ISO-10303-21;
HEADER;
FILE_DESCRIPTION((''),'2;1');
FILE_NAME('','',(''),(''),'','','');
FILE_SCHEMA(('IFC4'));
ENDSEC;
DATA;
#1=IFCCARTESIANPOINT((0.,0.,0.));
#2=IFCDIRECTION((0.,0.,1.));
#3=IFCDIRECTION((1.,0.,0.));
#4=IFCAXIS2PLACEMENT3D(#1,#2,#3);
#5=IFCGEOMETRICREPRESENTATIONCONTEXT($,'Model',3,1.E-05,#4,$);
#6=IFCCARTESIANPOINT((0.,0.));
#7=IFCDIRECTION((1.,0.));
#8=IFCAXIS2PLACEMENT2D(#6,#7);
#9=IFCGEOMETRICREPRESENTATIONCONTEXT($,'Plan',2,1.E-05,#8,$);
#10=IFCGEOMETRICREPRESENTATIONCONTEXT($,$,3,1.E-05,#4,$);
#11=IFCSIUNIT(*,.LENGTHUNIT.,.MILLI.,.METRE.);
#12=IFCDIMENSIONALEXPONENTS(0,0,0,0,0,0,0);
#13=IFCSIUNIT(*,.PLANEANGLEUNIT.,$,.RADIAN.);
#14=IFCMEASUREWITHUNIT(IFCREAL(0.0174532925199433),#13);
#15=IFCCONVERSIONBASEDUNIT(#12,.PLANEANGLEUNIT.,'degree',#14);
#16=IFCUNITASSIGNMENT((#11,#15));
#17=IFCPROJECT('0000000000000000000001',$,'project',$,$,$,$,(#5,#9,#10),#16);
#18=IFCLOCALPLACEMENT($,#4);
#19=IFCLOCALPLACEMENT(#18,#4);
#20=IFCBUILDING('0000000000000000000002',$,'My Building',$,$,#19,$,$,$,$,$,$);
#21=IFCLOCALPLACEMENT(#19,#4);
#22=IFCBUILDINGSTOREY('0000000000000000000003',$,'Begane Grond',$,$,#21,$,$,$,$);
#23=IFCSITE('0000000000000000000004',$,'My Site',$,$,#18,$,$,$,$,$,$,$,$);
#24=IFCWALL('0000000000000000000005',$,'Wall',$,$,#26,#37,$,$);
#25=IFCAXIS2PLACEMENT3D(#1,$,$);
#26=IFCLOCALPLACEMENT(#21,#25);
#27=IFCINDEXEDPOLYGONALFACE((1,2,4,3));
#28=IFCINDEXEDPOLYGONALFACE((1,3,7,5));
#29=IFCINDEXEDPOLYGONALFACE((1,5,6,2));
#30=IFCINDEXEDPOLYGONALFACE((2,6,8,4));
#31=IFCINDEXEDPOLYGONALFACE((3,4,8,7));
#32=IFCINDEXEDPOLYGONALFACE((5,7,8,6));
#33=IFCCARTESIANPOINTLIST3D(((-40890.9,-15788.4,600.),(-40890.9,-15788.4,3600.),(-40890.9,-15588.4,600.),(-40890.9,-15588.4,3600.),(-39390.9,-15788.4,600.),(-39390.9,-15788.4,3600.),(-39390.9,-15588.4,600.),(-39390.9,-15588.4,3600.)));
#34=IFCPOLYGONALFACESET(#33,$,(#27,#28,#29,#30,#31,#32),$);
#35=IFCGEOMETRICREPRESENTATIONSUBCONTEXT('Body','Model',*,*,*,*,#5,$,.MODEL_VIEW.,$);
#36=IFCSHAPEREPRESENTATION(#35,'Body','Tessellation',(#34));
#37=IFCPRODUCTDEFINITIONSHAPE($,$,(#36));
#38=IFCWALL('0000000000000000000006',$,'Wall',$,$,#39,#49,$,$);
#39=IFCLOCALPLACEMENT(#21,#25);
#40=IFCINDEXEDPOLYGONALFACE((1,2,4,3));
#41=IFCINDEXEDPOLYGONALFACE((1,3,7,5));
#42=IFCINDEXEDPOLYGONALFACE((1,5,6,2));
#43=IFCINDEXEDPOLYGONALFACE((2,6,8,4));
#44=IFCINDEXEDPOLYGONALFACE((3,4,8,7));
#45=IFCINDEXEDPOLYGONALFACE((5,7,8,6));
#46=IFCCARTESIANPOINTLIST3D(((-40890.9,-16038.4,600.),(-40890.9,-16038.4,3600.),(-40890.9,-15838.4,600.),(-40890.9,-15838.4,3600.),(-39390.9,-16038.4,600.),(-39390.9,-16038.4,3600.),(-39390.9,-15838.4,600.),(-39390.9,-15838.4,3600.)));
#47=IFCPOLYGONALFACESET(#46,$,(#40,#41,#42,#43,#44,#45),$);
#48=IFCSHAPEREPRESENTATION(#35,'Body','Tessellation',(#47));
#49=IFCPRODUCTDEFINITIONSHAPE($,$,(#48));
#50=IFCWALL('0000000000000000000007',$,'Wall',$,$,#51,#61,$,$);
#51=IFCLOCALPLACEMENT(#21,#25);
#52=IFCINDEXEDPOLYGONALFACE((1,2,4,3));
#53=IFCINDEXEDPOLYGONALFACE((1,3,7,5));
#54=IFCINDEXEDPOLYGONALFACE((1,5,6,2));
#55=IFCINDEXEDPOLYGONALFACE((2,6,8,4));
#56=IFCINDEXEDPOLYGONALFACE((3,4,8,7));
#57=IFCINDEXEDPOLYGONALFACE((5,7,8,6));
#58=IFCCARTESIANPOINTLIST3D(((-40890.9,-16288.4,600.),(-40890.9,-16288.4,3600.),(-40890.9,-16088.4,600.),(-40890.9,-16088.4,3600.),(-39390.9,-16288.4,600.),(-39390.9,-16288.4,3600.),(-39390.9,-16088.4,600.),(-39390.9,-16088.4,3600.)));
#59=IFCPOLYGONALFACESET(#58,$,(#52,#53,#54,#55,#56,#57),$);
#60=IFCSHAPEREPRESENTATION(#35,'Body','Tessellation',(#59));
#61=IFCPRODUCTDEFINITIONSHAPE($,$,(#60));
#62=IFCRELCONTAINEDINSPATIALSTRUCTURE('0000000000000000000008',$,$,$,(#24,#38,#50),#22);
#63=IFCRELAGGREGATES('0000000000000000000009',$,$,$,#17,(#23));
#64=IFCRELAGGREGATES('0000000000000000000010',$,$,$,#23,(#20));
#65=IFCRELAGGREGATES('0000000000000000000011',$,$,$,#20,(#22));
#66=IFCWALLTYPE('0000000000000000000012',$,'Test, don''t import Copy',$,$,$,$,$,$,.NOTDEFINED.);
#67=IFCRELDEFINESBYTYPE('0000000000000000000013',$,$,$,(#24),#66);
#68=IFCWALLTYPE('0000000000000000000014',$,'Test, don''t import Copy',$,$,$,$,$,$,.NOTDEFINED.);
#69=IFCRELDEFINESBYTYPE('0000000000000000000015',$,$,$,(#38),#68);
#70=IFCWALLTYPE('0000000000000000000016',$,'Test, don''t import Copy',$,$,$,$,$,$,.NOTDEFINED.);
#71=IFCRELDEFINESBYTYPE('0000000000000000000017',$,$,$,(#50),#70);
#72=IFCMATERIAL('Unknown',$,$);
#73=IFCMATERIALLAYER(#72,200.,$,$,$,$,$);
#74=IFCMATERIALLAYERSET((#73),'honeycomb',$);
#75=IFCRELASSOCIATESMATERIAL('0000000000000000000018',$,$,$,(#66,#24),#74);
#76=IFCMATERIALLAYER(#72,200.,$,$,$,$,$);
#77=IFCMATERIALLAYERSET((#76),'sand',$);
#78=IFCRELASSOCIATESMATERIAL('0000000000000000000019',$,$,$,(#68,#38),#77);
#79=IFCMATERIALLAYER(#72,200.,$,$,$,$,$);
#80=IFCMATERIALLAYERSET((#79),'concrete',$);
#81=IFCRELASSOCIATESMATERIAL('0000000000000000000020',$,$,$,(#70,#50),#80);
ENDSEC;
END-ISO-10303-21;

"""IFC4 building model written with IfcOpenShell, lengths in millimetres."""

from ifc_helpers import new_model, entity, si_unit, converted_unit, frame, origin_with_axes, origin_2d_with_axis, place, context, subcontext, project, spatial, indexed_curve, outline, extrude, material, layer, layer_set, layer_usage, type_object, element, save


model = new_model("IFC4")

# Units and contexts
model_context = context("Model", 3, precision=1e-05, world=origin_with_axes())
plan_context = context("Plan", 2, precision=1e-05, world=origin_2d_with_axis())
context_of_model = context(None, 3, precision=1e-05, world=origin_with_axes())
body_context = subcontext(model_context, "Body", "Model", "MODEL_VIEW")
ifc_project = project(units=[si_unit("LENGTHUNIT", "METRE", prefix="MILLI"), converted_unit("PLANEANGLEUNIT", "degree", entity("IfcReal", 0.0174532925199433), si_unit("PLANEANGLEUNIT", "RADIAN"), dimensions=[0, 0, 0, 0, 0, 0, 0])], contexts=[model_context, plan_context, context_of_model])

# Site, building, storey
site_placement = place(None, frame((0.0, 0.0, 0.0), z_axis=(0.0, 0.0, 1.0), x_axis=(1.0, 0.0, 0.0)))
site = spatial("IfcSite", under=ifc_project, at=site_placement, Name="My Site")
building_placement = place(site_placement, origin_with_axes())
building = spatial("IfcBuilding", under=site, at=building_placement, Name="My Building")
storey_placement = place(building_placement, origin_with_axes())
storey = spatial("IfcBuildingStorey", under=building, at=storey_placement, Name="Begane Grond")

# Walls
ifc_material_1 = material(Name="Unknown")
ifc_layer_1 = layer(ifc_material_1, 200.0)
ifc_layer_set_1 = layer_set([ifc_layer_1], Name="honeycomb")
ifc_layer_usage_1 = layer_usage(ifc_layer_set_1, "AXIS2", "POSITIVE", 0.0)
wall_type_1 = type_object("IfcWallType", Name="Test, don't import Copy", PredefinedType="NOTDEFINED", material=ifc_layer_set_1)
wall_1_placement = place(storey_placement, frame((-40890.9, -15788.4, 600.0), z_axis=(0.0, 0.0, 1.0), x_axis=(1.0, 0.0, 0.0)))
element("IfcWall", 1, at=wall_1_placement, inside=storey, type_object=wall_type_1, material=ifc_layer_usage_1, Name="Wall", context=body_context, shape_type="SweptSolid", body=[
    extrude(outline(indexed_curve([(0.0, 0.0), (0.0, 200.0), (1500.0, 200.0), (1500.0, 0.0), (0.0, 0.0)], self_intersect=False)), origin_with_axes(), (0.0, 0.0, 1.0), 3000.0),
])
ifc_layer_2 = layer(ifc_material_1, 200.0)
ifc_layer_set_2 = layer_set([ifc_layer_2], Name="sand")
ifc_layer_usage_2 = layer_usage(ifc_layer_set_2, "AXIS2", "POSITIVE", 0.0)
wall_type_2 = type_object("IfcWallType", Name="Test, don't import Copy", PredefinedType="NOTDEFINED", material=ifc_layer_set_2)
wall_2_placement = place(storey_placement, frame((-40890.9, -16038.4, 600.0), z_axis=(0.0, 0.0, 1.0), x_axis=(1.0, 0.0, 0.0)))
element("IfcWall", 2, at=wall_2_placement, inside=storey, type_object=wall_type_2, material=ifc_layer_usage_2, Name="Wall", context=body_context, shape_type="SweptSolid", body=[
    extrude(outline(indexed_curve([(0.0, 0.0), (0.0, 200.0), (1500.0, 200.0), (1500.0, 0.0), (0.0, 0.0)], self_intersect=False)), origin_with_axes(), (0.0, 0.0, 1.0), 3000.0),
])
ifc_layer_3 = layer(ifc_material_1, 200.0)
ifc_layer_set_3 = layer_set([ifc_layer_3], Name="concrete")
ifc_layer_usage_3 = layer_usage(ifc_layer_set_3, "AXIS2", "POSITIVE", 0.0)
wall_type_3 = type_object("IfcWallType", Name="Test, don't import Copy", PredefinedType="NOTDEFINED", material=ifc_layer_set_3)
wall_3_placement = place(storey_placement, frame((-40890.9, -16288.4, 600.0), z_axis=(0.0, 0.0, 1.0), x_axis=(1.0, 0.0, 0.0)))
element("IfcWall", 3, at=wall_3_placement, inside=storey, type_object=wall_type_3, material=ifc_layer_usage_3, Name="Wall", context=body_context, shape_type="SweptSolid", body=[
    extrude(outline(indexed_curve([(0.0, 0.0), (0.0, 200.0), (1500.0, 200.0), (1500.0, 0.0), (0.0, 0.0)], self_intersect=False)), origin_with_axes(), (0.0, 0.0, 1.0), 3000.0),
])

save(model, "model.ifc")
